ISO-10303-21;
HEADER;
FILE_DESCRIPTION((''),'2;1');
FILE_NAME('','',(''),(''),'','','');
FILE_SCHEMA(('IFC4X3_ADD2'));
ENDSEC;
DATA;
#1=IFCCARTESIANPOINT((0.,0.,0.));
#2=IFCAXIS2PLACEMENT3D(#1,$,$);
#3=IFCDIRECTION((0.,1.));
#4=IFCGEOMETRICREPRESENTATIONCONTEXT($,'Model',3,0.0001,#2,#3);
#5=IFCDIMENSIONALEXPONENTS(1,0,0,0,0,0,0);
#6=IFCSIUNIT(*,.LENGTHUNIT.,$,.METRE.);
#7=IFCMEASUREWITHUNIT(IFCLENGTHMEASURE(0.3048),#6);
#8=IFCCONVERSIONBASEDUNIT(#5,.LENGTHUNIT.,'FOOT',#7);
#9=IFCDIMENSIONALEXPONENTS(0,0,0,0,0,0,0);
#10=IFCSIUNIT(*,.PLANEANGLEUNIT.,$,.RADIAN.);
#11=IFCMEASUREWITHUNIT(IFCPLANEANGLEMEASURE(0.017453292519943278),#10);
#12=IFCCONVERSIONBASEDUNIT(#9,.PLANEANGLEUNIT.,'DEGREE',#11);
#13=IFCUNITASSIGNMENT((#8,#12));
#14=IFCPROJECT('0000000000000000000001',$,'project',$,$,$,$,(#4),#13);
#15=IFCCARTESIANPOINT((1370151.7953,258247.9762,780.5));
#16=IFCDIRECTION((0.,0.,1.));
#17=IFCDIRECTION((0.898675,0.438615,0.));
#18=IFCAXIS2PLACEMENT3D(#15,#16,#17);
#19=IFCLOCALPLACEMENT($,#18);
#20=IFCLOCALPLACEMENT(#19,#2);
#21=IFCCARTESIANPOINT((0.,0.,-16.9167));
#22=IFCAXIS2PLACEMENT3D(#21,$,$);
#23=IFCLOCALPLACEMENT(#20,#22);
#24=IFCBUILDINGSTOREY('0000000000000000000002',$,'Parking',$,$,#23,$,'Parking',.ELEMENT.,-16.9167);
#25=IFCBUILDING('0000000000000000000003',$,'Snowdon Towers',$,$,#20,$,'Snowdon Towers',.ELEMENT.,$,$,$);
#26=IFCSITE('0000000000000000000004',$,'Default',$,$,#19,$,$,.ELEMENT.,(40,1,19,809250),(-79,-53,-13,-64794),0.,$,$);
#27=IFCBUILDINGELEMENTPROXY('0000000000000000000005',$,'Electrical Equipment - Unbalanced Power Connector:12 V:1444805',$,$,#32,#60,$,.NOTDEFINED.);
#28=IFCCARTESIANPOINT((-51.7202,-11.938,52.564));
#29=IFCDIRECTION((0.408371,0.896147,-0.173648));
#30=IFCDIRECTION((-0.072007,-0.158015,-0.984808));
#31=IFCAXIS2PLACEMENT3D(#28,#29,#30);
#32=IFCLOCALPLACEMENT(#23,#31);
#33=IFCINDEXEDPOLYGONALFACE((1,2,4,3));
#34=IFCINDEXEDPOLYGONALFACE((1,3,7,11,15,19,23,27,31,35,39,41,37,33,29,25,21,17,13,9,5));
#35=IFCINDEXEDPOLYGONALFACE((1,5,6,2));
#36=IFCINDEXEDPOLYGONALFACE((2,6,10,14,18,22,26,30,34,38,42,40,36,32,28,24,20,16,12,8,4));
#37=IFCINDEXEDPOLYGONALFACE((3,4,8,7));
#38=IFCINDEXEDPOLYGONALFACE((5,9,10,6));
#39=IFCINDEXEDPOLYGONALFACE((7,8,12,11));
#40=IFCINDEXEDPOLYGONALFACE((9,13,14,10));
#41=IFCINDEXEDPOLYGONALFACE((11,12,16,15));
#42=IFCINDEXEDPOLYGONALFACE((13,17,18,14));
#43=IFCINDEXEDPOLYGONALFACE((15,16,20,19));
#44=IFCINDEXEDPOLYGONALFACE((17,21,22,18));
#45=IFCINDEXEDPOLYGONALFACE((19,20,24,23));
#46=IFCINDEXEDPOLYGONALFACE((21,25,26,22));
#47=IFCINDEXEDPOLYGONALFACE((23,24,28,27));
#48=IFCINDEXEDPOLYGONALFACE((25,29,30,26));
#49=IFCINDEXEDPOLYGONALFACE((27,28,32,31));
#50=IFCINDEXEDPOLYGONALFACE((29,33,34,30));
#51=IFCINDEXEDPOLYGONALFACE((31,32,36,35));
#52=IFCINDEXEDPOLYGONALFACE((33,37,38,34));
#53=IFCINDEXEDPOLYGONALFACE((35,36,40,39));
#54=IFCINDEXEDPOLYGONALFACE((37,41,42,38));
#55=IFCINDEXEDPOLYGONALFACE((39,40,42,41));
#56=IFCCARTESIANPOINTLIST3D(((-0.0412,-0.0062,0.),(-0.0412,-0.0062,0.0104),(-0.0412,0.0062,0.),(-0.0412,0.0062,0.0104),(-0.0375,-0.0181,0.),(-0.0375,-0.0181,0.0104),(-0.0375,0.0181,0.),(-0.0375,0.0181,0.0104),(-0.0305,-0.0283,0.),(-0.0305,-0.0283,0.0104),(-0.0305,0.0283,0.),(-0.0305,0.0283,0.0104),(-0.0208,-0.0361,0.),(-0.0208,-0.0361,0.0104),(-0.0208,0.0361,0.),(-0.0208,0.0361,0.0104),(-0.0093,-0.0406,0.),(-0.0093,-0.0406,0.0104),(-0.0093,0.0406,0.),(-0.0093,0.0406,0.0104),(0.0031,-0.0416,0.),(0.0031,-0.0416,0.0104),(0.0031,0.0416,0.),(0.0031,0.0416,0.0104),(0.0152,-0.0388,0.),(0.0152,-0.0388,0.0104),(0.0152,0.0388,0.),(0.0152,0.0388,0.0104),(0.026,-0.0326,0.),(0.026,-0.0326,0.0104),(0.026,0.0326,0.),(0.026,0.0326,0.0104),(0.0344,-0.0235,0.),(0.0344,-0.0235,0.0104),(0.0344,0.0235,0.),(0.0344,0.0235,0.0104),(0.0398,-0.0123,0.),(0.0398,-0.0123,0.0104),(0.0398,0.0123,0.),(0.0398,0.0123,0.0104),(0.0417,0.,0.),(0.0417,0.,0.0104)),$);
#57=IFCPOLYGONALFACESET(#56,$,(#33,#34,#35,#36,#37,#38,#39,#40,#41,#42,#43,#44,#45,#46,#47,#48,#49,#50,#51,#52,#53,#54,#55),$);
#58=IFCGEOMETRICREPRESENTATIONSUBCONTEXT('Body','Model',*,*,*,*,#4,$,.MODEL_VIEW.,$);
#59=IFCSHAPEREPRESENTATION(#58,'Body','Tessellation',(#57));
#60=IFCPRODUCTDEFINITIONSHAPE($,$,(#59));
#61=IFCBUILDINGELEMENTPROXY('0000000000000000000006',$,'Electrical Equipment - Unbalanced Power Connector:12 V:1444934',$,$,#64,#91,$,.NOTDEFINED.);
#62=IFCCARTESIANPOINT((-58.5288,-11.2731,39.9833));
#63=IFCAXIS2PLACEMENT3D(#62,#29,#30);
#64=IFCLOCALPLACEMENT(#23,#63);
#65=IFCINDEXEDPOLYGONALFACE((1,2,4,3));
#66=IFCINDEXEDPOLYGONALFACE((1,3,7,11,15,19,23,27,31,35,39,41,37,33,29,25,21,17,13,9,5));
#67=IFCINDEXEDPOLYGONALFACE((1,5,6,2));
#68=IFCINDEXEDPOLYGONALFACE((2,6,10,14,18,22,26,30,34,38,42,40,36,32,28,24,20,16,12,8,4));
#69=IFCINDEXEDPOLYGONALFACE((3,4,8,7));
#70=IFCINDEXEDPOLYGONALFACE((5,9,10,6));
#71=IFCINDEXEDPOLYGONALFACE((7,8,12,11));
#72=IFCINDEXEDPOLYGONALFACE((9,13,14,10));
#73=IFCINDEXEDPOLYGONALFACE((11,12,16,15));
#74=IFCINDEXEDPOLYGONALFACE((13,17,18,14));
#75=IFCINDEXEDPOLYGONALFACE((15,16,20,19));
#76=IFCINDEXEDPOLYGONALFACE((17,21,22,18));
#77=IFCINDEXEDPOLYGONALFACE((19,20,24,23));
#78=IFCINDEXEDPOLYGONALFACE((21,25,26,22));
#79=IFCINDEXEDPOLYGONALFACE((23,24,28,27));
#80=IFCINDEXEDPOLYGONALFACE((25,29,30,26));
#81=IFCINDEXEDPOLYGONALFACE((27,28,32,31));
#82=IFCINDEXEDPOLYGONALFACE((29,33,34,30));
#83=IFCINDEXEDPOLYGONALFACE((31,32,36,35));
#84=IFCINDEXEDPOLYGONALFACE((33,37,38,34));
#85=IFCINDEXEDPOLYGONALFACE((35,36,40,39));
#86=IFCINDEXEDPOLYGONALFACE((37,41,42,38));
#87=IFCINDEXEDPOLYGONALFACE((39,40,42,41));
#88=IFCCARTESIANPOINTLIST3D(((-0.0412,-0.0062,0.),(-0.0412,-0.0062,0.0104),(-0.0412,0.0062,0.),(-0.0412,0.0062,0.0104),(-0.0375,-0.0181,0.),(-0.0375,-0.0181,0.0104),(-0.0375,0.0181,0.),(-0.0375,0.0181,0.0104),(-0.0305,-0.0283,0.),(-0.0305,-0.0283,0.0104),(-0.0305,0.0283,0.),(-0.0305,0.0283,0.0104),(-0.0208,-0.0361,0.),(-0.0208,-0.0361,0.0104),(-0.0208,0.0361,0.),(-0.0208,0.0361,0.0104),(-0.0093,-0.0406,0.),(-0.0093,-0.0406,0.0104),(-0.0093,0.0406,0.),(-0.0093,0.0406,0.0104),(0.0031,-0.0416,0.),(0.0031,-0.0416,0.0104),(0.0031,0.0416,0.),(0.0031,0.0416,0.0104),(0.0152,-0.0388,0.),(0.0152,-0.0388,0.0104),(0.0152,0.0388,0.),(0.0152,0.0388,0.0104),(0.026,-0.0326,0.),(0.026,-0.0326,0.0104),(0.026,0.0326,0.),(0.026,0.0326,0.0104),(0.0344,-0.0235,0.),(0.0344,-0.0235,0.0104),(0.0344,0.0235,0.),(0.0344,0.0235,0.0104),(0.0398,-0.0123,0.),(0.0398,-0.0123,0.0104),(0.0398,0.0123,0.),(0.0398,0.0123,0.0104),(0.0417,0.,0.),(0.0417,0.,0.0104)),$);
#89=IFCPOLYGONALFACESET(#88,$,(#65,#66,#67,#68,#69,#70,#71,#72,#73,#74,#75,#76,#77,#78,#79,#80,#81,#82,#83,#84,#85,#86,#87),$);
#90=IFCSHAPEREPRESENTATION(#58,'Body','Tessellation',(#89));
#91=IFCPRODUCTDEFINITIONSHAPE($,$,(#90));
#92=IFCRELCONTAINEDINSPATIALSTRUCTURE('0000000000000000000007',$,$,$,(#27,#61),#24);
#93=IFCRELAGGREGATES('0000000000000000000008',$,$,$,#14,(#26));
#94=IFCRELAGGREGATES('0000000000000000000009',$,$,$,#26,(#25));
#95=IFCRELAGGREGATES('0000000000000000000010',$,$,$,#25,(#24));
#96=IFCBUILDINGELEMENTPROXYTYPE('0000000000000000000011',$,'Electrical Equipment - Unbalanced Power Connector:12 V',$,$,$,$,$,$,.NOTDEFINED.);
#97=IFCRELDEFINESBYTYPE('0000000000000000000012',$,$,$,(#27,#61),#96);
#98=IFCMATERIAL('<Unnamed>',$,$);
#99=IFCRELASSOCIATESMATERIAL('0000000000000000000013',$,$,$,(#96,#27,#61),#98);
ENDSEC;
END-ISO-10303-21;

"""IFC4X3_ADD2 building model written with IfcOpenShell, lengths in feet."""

from ifc_helpers import new_model, entity, si_unit, converted_unit, direction, frame, frame_2d, origin, place, context, subcontext, project, spatial, circle, extrude, source, transform, mapped, material, type_object, type_shapes, element, save


model = new_model("IFC4X3_ADD2")

# Units and contexts
model_context = context("Model", 3, precision=0.0001, world=origin(), true_north=direction((0.0, 1.0)))
body_context = subcontext(model_context, "Body", "Model", "MODEL_VIEW")
ifc_project = project(units=[converted_unit("LENGTHUNIT", "FOOT", entity("IfcLengthMeasure", 0.3048), si_unit("LENGTHUNIT", "METRE"), dimensions=[1, 0, 0, 0, 0, 0, 0]), converted_unit("PLANEANGLEUNIT", "DEGREE", entity("IfcPlaneAngleMeasure", 0.017453292519943278), si_unit("PLANEANGLEUNIT", "RADIAN"), dimensions=[0, 0, 0, 0, 0, 0, 0])], contexts=[model_context])

# Site, building, storey
site_placement = place(None, frame((1370151.7953, 258247.9762, 780.5), z_axis=(0.0, 0.0, 1.0), x_axis=(0.898675, 0.438615, 0.0)))
site = spatial("IfcSite", under=ifc_project, at=site_placement, Name="Default", CompositionType="ELEMENT", RefLatitude=(40, 1, 19, 809250), RefLongitude=(-79, -53, -13, -64794), RefElevation=0.0)
building_placement = place(site_placement, origin())
building = spatial("IfcBuilding", under=site, at=building_placement, Name="Snowdon Towers", LongName="Snowdon Towers", CompositionType="ELEMENT")
storey_placement = place(building_placement, frame((0.0, 0.0, -16.9167)))
storey = spatial("IfcBuildingStorey", under=building, at=storey_placement, Name="Parking", LongName="Parking", CompositionType="ELEMENT", Elevation=-16.9167)

# Building element proxies
ifc_material_1 = material(Name="<Unnamed>")
building_element_proxy_type = type_object("IfcBuildingElementProxyType", Name="Electrical Equipment - Unbalanced Power Connector:12 V", PredefinedType="NOTDEFINED", material=ifc_material_1)
shared_shape_1 = source(origin(), body_context, "Body", "SweptSolid", [
    extrude(circle(Radius=0.0417, at=frame_2d((0.0, 0.0), x_axis=(1.0, 0.0))), origin(), (0.0, 0.0, 1.0), 0.0104),
])
type_shapes(building_element_proxy_type, [shared_shape_1])
for number, where, z_axis, x_axis, name in (
    (1, (-51.7202, -11.938, 52.564), (0.408371, 0.896147, -0.173648), (-0.072007, -0.158015, -0.984808), "Electrical Equipment - Unbalanced Power Connector:12 V:1444805"),
    (2, (-58.5288, -11.2731, 39.9833), (0.408371, 0.896147, -0.173648), (-0.072007, -0.158015, -0.984808), "Electrical Equipment - Unbalanced Power Connector:12 V:1444934"),
):
    element("IfcBuildingElementProxy", number, at=place(storey_placement, frame(where, z_axis=z_axis, x_axis=x_axis)), inside=storey, type_object=building_element_proxy_type, material=ifc_material_1, Name=name, PredefinedType="NOTDEFINED", context=body_context, shape_type="MappedRepresentation", body=[
        mapped(shared_shape_1, transform((0.0, 0.0, 0.0), scale=1.0)),
    ])

save(model, "model.ifc")
